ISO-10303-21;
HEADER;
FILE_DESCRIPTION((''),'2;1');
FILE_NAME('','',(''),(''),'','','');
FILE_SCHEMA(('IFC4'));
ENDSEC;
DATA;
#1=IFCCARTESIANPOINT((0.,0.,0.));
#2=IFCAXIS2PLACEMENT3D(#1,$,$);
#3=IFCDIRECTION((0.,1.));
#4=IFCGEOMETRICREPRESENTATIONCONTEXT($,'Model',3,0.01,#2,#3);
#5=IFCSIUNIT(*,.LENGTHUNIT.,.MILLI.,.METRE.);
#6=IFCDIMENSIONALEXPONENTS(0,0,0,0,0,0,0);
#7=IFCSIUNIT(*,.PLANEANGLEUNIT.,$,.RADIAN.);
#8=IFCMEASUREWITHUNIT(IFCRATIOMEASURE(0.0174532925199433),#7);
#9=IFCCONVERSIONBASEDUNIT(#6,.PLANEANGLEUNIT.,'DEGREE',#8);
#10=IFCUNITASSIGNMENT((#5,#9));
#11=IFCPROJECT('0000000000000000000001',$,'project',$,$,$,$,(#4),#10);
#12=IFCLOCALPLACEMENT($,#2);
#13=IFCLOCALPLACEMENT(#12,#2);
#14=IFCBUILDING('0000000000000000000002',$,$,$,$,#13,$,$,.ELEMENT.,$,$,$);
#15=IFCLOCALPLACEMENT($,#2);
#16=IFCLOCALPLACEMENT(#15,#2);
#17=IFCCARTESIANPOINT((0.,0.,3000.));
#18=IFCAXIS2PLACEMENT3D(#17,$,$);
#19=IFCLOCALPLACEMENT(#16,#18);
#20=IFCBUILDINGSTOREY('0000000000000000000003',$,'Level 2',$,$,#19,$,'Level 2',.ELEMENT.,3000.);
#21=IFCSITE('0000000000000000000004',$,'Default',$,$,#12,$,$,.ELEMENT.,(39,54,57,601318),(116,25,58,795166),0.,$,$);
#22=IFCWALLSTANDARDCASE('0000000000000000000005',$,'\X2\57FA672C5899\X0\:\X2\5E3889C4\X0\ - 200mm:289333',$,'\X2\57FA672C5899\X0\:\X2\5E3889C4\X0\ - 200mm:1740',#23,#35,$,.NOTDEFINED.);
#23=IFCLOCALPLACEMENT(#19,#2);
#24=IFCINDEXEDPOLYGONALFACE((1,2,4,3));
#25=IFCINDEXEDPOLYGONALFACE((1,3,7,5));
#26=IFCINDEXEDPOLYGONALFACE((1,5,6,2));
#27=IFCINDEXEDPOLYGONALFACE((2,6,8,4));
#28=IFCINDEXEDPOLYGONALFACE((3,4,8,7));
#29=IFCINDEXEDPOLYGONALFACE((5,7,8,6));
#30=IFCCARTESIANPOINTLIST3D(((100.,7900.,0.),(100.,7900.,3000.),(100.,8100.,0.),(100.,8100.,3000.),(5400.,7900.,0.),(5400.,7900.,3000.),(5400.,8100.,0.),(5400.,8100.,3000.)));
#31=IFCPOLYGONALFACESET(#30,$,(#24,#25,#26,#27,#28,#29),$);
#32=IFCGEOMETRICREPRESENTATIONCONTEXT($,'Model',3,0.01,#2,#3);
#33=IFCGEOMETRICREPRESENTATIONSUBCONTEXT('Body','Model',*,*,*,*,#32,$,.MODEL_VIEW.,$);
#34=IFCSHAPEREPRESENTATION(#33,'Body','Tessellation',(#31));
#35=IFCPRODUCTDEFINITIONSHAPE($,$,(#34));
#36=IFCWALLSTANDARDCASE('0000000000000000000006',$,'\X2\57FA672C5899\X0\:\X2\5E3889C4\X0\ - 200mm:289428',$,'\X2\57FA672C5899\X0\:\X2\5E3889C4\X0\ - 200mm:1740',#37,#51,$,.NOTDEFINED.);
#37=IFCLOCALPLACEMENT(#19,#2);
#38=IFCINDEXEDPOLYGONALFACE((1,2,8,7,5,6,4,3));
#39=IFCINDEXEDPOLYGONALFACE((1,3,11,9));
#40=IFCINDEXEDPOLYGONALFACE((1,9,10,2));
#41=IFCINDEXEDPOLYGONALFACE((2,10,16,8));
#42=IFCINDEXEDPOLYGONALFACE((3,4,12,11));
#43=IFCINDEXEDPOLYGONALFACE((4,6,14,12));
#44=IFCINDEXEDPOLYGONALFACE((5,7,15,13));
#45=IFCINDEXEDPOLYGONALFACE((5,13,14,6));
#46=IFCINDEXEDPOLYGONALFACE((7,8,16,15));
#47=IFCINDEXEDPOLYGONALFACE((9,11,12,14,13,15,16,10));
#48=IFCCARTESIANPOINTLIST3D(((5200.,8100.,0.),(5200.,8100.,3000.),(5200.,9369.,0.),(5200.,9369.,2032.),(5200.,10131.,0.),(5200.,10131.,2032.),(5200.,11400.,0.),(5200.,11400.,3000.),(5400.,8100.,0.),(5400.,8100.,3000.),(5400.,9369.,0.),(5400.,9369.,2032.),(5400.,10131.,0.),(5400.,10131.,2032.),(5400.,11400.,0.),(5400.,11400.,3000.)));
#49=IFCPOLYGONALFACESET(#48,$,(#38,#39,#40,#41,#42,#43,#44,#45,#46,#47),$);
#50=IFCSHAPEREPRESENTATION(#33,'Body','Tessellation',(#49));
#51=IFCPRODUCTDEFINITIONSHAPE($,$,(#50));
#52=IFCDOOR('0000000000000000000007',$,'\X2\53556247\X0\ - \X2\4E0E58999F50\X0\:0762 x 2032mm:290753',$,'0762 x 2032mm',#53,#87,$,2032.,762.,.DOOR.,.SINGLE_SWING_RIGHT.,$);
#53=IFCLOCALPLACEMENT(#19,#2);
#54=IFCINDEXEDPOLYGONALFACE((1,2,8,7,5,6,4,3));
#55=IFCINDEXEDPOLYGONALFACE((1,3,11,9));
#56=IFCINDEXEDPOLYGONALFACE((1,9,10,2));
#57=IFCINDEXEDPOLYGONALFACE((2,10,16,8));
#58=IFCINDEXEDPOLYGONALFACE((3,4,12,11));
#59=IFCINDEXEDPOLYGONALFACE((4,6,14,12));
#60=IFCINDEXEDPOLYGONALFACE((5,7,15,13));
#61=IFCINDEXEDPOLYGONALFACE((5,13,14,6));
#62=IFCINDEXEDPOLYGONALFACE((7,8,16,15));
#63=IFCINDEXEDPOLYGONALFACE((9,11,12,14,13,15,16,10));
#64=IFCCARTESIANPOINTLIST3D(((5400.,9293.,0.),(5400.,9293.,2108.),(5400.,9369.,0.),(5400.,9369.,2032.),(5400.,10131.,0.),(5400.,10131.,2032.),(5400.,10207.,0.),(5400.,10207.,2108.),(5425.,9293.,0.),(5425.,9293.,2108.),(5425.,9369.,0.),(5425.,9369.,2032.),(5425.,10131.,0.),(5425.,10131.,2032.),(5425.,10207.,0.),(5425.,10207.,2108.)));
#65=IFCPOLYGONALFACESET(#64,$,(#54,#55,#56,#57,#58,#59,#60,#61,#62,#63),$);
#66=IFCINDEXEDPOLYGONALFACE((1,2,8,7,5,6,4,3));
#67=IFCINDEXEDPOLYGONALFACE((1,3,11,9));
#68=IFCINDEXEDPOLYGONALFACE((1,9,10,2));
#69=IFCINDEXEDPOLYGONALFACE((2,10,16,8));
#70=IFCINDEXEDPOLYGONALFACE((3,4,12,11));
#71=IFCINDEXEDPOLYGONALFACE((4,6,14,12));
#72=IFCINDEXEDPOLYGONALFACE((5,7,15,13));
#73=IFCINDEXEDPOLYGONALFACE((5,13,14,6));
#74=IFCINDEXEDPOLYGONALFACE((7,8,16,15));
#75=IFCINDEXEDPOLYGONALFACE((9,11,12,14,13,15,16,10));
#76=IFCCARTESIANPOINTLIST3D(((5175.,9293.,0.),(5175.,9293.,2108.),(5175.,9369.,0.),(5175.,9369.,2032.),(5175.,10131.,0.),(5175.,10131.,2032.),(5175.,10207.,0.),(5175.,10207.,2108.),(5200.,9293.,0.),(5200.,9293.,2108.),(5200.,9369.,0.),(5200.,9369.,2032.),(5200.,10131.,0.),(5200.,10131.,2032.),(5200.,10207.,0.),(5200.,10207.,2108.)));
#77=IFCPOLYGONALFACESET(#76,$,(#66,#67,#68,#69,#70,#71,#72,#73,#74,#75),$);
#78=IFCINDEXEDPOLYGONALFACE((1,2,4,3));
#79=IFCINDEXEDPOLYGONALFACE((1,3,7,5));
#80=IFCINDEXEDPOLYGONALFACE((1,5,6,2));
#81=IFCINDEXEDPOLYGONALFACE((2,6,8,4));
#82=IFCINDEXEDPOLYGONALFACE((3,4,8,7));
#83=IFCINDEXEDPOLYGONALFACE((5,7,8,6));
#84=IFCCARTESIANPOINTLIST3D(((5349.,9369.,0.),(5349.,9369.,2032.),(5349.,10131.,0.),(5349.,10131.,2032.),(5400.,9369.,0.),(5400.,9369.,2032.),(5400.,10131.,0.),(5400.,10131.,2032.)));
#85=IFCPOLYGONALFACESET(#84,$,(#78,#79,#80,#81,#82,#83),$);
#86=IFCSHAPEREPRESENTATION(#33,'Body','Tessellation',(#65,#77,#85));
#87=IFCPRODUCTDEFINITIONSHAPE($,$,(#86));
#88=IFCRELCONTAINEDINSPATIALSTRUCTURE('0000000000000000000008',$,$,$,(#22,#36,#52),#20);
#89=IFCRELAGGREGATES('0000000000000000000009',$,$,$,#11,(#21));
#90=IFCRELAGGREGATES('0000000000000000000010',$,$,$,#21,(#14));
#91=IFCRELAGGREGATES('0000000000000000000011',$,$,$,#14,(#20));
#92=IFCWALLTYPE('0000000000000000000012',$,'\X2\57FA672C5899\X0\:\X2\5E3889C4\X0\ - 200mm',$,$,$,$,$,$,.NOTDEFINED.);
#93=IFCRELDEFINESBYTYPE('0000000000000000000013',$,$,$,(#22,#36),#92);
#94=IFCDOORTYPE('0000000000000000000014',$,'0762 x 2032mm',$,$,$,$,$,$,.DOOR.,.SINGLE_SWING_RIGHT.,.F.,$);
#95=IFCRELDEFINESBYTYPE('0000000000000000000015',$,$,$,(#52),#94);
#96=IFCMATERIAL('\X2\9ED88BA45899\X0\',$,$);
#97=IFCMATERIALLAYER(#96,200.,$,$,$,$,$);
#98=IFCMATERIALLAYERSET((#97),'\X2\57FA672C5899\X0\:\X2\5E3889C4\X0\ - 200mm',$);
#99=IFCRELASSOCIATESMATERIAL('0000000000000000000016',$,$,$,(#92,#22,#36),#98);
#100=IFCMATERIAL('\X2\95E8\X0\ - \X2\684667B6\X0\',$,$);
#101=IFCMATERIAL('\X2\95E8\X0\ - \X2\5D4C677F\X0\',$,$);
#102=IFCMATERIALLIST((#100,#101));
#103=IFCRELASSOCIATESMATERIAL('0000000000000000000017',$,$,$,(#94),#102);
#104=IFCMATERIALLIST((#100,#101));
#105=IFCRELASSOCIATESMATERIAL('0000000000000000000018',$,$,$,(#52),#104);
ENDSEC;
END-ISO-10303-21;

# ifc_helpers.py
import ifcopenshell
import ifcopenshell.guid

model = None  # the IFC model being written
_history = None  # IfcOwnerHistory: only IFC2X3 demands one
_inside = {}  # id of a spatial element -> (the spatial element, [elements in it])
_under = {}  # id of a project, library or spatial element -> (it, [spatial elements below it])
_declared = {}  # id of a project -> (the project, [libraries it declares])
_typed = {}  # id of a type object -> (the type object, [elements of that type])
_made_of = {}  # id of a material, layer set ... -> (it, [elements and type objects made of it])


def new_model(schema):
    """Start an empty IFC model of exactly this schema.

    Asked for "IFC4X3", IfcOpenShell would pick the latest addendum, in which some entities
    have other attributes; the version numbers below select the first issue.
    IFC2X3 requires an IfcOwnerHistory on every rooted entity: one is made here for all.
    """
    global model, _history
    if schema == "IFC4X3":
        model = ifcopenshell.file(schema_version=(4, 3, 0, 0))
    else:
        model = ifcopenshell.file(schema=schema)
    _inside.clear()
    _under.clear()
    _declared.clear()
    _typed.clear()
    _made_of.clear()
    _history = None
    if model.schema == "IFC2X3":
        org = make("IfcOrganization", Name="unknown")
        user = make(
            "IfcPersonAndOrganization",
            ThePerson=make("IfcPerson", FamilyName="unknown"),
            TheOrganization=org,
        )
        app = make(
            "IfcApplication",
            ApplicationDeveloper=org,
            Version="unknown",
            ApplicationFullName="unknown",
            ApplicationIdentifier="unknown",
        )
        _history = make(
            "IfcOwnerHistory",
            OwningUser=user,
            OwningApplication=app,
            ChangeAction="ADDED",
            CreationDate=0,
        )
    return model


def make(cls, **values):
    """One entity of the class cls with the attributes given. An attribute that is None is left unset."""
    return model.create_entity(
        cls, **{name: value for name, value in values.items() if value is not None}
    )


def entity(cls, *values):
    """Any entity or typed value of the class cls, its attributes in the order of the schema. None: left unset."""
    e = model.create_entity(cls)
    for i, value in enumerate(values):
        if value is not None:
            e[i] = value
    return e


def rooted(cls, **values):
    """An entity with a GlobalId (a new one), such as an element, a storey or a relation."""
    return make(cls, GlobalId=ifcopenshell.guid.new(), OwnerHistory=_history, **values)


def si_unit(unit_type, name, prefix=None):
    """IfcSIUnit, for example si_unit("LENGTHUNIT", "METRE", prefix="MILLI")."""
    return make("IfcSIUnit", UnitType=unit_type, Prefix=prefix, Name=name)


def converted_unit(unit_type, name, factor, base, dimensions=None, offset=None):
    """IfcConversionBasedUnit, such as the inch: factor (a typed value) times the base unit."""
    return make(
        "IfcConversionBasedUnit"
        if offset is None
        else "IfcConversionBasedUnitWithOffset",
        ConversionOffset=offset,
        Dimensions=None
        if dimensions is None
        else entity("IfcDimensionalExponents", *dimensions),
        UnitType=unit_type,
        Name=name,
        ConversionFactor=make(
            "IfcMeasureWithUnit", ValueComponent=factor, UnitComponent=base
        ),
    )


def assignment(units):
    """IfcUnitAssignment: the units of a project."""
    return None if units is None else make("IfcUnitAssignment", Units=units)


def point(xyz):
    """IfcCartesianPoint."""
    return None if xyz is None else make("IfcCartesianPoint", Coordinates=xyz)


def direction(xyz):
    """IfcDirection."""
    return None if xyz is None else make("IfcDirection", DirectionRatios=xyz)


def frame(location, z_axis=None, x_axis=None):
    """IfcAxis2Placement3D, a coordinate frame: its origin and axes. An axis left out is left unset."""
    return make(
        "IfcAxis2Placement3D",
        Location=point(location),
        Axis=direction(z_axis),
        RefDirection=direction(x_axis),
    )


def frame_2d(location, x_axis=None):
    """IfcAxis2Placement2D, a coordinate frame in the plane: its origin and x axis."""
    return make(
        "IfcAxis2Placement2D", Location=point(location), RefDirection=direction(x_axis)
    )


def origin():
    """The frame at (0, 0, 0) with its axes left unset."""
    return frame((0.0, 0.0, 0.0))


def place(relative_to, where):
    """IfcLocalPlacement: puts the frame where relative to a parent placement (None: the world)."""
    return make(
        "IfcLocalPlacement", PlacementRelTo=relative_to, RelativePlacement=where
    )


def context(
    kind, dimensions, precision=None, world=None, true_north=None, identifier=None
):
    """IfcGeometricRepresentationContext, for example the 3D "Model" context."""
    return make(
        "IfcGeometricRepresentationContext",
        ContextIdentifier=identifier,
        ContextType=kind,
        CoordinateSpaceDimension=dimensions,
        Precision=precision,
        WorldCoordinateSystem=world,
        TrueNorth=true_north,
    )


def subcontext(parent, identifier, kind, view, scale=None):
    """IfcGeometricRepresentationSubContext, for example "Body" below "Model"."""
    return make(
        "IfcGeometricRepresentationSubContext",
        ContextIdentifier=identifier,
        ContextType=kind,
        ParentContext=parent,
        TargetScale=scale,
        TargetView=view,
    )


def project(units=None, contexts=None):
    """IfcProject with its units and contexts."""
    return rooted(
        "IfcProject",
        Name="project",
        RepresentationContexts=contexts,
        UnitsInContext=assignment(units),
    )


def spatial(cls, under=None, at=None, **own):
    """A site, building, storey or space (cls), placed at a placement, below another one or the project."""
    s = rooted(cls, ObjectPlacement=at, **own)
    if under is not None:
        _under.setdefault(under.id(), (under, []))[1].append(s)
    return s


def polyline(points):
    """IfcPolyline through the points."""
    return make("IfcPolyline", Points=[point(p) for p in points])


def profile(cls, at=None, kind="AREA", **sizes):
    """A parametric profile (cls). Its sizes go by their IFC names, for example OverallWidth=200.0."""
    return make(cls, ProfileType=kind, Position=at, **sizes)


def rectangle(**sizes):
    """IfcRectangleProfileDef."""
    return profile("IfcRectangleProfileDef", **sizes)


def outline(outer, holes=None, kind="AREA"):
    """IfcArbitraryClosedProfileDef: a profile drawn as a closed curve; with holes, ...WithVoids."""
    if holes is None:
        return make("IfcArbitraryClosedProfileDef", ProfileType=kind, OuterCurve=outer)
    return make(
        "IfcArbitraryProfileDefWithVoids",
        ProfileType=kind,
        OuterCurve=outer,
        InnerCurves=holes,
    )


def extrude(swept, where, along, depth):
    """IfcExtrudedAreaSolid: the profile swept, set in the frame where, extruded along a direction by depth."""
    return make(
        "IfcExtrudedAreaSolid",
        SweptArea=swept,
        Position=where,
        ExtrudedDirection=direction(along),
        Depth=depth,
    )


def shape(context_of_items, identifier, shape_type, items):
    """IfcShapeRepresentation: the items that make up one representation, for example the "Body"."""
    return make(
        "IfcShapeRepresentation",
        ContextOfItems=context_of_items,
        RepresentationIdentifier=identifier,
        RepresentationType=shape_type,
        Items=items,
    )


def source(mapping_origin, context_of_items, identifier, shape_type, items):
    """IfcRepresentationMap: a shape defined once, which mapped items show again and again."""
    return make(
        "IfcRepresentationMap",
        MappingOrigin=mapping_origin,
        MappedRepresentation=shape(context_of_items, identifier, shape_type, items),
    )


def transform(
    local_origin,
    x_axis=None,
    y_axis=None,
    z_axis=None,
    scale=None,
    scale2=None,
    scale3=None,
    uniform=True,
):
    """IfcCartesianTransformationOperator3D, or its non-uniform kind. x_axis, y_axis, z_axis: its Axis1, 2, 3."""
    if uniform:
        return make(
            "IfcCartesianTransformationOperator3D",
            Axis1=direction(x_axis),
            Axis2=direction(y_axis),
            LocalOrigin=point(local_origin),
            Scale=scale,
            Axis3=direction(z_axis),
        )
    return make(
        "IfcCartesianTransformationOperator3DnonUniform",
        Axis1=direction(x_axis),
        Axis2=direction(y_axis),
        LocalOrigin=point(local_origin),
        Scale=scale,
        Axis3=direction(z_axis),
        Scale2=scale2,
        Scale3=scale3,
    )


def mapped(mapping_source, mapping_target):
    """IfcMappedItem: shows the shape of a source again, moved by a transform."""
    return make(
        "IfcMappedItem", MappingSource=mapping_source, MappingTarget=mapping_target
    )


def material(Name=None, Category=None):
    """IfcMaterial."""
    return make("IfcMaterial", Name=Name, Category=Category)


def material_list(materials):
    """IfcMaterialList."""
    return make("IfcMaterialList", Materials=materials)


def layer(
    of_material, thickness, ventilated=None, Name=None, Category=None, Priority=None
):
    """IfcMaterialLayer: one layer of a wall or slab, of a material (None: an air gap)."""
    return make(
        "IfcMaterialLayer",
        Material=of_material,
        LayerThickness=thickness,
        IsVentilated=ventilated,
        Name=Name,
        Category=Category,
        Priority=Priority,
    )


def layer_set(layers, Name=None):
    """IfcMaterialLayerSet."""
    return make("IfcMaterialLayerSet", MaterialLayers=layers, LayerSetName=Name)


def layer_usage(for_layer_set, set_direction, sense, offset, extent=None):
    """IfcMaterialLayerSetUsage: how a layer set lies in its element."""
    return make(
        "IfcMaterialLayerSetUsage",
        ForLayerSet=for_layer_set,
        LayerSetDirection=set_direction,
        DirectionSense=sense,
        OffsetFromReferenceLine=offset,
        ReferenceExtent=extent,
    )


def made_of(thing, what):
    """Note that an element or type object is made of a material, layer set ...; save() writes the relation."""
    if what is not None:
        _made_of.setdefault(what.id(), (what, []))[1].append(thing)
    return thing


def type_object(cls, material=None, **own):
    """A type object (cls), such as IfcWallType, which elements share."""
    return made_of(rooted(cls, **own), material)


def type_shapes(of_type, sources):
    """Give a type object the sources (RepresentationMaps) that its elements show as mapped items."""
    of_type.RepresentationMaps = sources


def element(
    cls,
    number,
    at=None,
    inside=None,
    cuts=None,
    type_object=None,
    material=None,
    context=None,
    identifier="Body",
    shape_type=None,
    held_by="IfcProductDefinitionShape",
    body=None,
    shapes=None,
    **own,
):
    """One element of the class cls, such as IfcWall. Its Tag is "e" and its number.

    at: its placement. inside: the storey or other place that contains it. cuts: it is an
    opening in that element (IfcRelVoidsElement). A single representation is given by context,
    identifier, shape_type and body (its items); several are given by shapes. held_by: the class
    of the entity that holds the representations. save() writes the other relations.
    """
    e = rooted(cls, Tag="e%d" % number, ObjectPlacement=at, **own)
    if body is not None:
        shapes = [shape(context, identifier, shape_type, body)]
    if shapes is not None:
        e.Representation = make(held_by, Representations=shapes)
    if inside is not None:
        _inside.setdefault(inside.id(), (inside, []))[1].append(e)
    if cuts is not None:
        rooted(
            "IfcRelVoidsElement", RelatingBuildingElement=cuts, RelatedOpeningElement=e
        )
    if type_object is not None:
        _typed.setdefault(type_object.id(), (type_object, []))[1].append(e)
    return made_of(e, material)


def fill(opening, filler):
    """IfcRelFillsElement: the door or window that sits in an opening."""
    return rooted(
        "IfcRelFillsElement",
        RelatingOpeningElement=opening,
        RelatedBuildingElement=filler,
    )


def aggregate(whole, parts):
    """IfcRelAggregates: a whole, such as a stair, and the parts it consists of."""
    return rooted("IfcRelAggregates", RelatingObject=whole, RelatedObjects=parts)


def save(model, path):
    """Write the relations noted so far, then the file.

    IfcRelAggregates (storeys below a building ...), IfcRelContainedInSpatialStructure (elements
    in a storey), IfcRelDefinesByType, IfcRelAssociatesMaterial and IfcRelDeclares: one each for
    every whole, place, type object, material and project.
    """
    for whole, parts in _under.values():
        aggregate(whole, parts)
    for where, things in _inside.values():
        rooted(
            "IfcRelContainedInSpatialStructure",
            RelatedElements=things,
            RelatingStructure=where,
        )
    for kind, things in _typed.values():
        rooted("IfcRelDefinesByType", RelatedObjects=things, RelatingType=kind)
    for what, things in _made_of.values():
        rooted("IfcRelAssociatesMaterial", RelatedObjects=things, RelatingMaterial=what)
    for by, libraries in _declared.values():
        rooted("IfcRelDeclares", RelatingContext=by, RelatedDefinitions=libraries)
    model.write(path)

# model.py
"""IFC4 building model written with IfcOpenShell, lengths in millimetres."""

from ifc_helpers import new_model, entity, si_unit, converted_unit, direction, frame, frame_2d, origin, place, context, subcontext, project, spatial, polyline, rectangle, outline, extrude, source, transform, mapped, material, material_list, layer, layer_set, layer_usage, type_object, type_shapes, element, fill, save


model = new_model("IFC4")

# Units and contexts
model_context_1 = context("Model", 3, precision=0.01, world=origin(), true_north=direction((0.0, 1.0)))
model_context_2 = context("Model", 3, precision=0.01, world=origin(), true_north=direction((0.0, 1.0)))
body_context = subcontext(model_context_2, "Body", "Model", "MODEL_VIEW")
ifc_project = project(units=[si_unit("LENGTHUNIT", "METRE", prefix="MILLI"), converted_unit("PLANEANGLEUNIT", "DEGREE", entity("IfcRatioMeasure", 0.0174532925199433), si_unit("PLANEANGLEUNIT", "RADIAN"), dimensions=[0, 0, 0, 0, 0, 0, 0])], contexts=[model_context_1])

# Site, building, storey
site_placement = place(None, origin())
site = spatial("IfcSite", under=ifc_project, at=site_placement, Name="Default", CompositionType="ELEMENT", RefLatitude=(39, 54, 57, 601318), RefLongitude=(116, 25, 58, 795166), RefElevation=0.0)
building_placement = place(site_placement, origin())
building = spatial("IfcBuilding", under=site, at=building_placement, CompositionType="ELEMENT")
placement_1 = place(None, origin())
placement_2 = place(placement_1, origin())
storey_placement = place(placement_2, frame((0.0, 0.0, 3000.0)))
storey = spatial("IfcBuildingStorey", under=building, at=storey_placement, Name="Level 2", LongName="Level 2", CompositionType="ELEMENT", Elevation=3000.0)

# Shared definitions
ifc_material_1 = material(Name="默认墙")
ifc_layer_1 = layer(ifc_material_1, 200.0)
ifc_layer_set_1 = layer_set([ifc_layer_1], Name="基本墙:常规 - 200mm")
wall_type = type_object("IfcWallType", Name="基本墙:常规 - 200mm", PredefinedType="NOTDEFINED", material=ifc_layer_set_1)

# Wall
ifc_layer_usage_1 = layer_usage(ifc_layer_set_1, "AXIS2", "NEGATIVE", 100.0)
wall_1_placement = place(storey_placement, frame((100.0, 8000.0, 0.0)))
element("IfcWallStandardCase", 1, at=wall_1_placement, inside=storey, type_object=wall_type, material=ifc_layer_usage_1, Name="基本墙:常规 - 200mm:289333", ObjectType="基本墙:常规 - 200mm:1740", PredefinedType="NOTDEFINED", context=body_context, shape_type="SweptSolid", body=[
    extrude(rectangle(XDim=5300.0, YDim=200.0, at=frame_2d((2650.0, 0.0), x_axis=(-1.0, 0.0))), origin(), (0.0, 0.0, 1.0), 3000.0),
])

# Wall, opening, door
ifc_layer_usage_2 = layer_usage(ifc_layer_set_1, "AXIS2", "NEGATIVE", 100.0)
wall_2_placement = place(storey_placement, frame((5300.0, 8100.0, 0.0), z_axis=(0.0, 0.0, 1.0), x_axis=(0.0, 1.0, 0.0)))
wall_2 = element("IfcWallStandardCase", 2, at=wall_2_placement, inside=storey, type_object=wall_type, material=ifc_layer_usage_2, Name="基本墙:常规 - 200mm:289428", ObjectType="基本墙:常规 - 200mm:1740", PredefinedType="NOTDEFINED", context=body_context, shape_type="SweptSolid", body=[
    extrude(rectangle(XDim=3300.0, YDim=200.0, at=frame_2d((1650.0, 0.0), x_axis=(-1.0, 0.0))), origin(), (0.0, 0.0, 1.0), 3000.0),
])
opening_1_placement = place(wall_2_placement, frame((2031.0, 100.0, 0.0)))
opening_1 = element("IfcOpeningElement", 3, at=opening_1_placement, cuts=wall_2, ObjectType="Opening", PredefinedType="OPENING", context=body_context, shape_type="SweptSolid", body=[
    extrude(rectangle(XDim=762.0, YDim=2032.0, at=frame_2d((1016.0, 381.0), x_axis=(0.0, 1.0))), frame((0.0, 0.0, 0.0), z_axis=(0.0, -1.0, 0.0), x_axis=(0.0, 0.0, 1.0)), (0.0, 0.0, 1.0), 200.0),
])
ifc_material_2 = material(Name="门 - 框架")
ifc_material_3 = material(Name="门 - 嵌板")
ifc_material_list_1 = material_list([ifc_material_2, ifc_material_3])
ifc_material_list_2 = material_list([ifc_material_2, ifc_material_3])
door_type = type_object("IfcDoorType", Name="0762 x 2032mm", OperationType="SINGLE_SWING_RIGHT", ParameterTakesPrecedence=False, PredefinedType="DOOR", material=ifc_material_list_2)
shared_shape_1 = source(origin(), body_context, "Body", "SweptSolid", [
    extrude(outline(polyline([(-457.0, -1073.0), (457.0, -1073.0), (457.0, 1035.0), (381.0, 1035.0), (381.0, -997.0), (-381.0, -997.0), (-381.0, 1035.0), (-457.0, 1035.0), (-457.0, -1073.0)])), frame((381.0, 200.0, 1035.0), z_axis=(0.0, 1.0, 0.0), x_axis=(1.0, 0.0, 0.0)), (0.0, 0.0, 1.0), 25.0),
    extrude(outline(polyline([(-1073.0, -457.0), (1035.0, -457.0), (1035.0, -381.0), (-997.0, -381.0), (-997.0, 381.0), (1035.0, 381.0), (1035.0, 457.0), (-1073.0, 457.0), (-1073.0, -457.0)])), frame((381.0, -25.0, 1035.0), z_axis=(0.0, 1.0, 0.0), x_axis=(0.0, 0.0, -1.0)), (0.0, 0.0, 1.0), 25.0),
    extrude(rectangle(XDim=51.0, YDim=762.0, at=frame_2d((0.0, 0.0), x_axis=(1.0, 0.0))), frame((381.0, 174.5, 0.0), z_axis=(0.0, 0.0, 1.0), x_axis=(0.0, 1.0, 0.0)), (0.0, 0.0, 1.0), 2032.0),
])
type_shapes(door_type, [shared_shape_1])
door_placement = place(opening_1_placement, frame((0.0, 0.0, 0.0), z_axis=(0.0, 0.0, 1.0), x_axis=(-1.0, 0.0, 0.0)))
door = element("IfcDoor", 4, at=door_placement, inside=storey, type_object=door_type, material=ifc_material_list_1, Name="单扇 - 与墙齐:0762 x 2032mm:290753", ObjectType="0762 x 2032mm", OperationType="SINGLE_SWING_RIGHT", OverallHeight=2032.0, OverallWidth=762.0, PredefinedType="DOOR", context=body_context, shape_type="MappedRepresentation", body=[
    mapped(shared_shape_1, transform((0.0, 0.0, 0.0), scale=1.0)),
])
fill(opening_1, door)

save(model, "model.ifc")
